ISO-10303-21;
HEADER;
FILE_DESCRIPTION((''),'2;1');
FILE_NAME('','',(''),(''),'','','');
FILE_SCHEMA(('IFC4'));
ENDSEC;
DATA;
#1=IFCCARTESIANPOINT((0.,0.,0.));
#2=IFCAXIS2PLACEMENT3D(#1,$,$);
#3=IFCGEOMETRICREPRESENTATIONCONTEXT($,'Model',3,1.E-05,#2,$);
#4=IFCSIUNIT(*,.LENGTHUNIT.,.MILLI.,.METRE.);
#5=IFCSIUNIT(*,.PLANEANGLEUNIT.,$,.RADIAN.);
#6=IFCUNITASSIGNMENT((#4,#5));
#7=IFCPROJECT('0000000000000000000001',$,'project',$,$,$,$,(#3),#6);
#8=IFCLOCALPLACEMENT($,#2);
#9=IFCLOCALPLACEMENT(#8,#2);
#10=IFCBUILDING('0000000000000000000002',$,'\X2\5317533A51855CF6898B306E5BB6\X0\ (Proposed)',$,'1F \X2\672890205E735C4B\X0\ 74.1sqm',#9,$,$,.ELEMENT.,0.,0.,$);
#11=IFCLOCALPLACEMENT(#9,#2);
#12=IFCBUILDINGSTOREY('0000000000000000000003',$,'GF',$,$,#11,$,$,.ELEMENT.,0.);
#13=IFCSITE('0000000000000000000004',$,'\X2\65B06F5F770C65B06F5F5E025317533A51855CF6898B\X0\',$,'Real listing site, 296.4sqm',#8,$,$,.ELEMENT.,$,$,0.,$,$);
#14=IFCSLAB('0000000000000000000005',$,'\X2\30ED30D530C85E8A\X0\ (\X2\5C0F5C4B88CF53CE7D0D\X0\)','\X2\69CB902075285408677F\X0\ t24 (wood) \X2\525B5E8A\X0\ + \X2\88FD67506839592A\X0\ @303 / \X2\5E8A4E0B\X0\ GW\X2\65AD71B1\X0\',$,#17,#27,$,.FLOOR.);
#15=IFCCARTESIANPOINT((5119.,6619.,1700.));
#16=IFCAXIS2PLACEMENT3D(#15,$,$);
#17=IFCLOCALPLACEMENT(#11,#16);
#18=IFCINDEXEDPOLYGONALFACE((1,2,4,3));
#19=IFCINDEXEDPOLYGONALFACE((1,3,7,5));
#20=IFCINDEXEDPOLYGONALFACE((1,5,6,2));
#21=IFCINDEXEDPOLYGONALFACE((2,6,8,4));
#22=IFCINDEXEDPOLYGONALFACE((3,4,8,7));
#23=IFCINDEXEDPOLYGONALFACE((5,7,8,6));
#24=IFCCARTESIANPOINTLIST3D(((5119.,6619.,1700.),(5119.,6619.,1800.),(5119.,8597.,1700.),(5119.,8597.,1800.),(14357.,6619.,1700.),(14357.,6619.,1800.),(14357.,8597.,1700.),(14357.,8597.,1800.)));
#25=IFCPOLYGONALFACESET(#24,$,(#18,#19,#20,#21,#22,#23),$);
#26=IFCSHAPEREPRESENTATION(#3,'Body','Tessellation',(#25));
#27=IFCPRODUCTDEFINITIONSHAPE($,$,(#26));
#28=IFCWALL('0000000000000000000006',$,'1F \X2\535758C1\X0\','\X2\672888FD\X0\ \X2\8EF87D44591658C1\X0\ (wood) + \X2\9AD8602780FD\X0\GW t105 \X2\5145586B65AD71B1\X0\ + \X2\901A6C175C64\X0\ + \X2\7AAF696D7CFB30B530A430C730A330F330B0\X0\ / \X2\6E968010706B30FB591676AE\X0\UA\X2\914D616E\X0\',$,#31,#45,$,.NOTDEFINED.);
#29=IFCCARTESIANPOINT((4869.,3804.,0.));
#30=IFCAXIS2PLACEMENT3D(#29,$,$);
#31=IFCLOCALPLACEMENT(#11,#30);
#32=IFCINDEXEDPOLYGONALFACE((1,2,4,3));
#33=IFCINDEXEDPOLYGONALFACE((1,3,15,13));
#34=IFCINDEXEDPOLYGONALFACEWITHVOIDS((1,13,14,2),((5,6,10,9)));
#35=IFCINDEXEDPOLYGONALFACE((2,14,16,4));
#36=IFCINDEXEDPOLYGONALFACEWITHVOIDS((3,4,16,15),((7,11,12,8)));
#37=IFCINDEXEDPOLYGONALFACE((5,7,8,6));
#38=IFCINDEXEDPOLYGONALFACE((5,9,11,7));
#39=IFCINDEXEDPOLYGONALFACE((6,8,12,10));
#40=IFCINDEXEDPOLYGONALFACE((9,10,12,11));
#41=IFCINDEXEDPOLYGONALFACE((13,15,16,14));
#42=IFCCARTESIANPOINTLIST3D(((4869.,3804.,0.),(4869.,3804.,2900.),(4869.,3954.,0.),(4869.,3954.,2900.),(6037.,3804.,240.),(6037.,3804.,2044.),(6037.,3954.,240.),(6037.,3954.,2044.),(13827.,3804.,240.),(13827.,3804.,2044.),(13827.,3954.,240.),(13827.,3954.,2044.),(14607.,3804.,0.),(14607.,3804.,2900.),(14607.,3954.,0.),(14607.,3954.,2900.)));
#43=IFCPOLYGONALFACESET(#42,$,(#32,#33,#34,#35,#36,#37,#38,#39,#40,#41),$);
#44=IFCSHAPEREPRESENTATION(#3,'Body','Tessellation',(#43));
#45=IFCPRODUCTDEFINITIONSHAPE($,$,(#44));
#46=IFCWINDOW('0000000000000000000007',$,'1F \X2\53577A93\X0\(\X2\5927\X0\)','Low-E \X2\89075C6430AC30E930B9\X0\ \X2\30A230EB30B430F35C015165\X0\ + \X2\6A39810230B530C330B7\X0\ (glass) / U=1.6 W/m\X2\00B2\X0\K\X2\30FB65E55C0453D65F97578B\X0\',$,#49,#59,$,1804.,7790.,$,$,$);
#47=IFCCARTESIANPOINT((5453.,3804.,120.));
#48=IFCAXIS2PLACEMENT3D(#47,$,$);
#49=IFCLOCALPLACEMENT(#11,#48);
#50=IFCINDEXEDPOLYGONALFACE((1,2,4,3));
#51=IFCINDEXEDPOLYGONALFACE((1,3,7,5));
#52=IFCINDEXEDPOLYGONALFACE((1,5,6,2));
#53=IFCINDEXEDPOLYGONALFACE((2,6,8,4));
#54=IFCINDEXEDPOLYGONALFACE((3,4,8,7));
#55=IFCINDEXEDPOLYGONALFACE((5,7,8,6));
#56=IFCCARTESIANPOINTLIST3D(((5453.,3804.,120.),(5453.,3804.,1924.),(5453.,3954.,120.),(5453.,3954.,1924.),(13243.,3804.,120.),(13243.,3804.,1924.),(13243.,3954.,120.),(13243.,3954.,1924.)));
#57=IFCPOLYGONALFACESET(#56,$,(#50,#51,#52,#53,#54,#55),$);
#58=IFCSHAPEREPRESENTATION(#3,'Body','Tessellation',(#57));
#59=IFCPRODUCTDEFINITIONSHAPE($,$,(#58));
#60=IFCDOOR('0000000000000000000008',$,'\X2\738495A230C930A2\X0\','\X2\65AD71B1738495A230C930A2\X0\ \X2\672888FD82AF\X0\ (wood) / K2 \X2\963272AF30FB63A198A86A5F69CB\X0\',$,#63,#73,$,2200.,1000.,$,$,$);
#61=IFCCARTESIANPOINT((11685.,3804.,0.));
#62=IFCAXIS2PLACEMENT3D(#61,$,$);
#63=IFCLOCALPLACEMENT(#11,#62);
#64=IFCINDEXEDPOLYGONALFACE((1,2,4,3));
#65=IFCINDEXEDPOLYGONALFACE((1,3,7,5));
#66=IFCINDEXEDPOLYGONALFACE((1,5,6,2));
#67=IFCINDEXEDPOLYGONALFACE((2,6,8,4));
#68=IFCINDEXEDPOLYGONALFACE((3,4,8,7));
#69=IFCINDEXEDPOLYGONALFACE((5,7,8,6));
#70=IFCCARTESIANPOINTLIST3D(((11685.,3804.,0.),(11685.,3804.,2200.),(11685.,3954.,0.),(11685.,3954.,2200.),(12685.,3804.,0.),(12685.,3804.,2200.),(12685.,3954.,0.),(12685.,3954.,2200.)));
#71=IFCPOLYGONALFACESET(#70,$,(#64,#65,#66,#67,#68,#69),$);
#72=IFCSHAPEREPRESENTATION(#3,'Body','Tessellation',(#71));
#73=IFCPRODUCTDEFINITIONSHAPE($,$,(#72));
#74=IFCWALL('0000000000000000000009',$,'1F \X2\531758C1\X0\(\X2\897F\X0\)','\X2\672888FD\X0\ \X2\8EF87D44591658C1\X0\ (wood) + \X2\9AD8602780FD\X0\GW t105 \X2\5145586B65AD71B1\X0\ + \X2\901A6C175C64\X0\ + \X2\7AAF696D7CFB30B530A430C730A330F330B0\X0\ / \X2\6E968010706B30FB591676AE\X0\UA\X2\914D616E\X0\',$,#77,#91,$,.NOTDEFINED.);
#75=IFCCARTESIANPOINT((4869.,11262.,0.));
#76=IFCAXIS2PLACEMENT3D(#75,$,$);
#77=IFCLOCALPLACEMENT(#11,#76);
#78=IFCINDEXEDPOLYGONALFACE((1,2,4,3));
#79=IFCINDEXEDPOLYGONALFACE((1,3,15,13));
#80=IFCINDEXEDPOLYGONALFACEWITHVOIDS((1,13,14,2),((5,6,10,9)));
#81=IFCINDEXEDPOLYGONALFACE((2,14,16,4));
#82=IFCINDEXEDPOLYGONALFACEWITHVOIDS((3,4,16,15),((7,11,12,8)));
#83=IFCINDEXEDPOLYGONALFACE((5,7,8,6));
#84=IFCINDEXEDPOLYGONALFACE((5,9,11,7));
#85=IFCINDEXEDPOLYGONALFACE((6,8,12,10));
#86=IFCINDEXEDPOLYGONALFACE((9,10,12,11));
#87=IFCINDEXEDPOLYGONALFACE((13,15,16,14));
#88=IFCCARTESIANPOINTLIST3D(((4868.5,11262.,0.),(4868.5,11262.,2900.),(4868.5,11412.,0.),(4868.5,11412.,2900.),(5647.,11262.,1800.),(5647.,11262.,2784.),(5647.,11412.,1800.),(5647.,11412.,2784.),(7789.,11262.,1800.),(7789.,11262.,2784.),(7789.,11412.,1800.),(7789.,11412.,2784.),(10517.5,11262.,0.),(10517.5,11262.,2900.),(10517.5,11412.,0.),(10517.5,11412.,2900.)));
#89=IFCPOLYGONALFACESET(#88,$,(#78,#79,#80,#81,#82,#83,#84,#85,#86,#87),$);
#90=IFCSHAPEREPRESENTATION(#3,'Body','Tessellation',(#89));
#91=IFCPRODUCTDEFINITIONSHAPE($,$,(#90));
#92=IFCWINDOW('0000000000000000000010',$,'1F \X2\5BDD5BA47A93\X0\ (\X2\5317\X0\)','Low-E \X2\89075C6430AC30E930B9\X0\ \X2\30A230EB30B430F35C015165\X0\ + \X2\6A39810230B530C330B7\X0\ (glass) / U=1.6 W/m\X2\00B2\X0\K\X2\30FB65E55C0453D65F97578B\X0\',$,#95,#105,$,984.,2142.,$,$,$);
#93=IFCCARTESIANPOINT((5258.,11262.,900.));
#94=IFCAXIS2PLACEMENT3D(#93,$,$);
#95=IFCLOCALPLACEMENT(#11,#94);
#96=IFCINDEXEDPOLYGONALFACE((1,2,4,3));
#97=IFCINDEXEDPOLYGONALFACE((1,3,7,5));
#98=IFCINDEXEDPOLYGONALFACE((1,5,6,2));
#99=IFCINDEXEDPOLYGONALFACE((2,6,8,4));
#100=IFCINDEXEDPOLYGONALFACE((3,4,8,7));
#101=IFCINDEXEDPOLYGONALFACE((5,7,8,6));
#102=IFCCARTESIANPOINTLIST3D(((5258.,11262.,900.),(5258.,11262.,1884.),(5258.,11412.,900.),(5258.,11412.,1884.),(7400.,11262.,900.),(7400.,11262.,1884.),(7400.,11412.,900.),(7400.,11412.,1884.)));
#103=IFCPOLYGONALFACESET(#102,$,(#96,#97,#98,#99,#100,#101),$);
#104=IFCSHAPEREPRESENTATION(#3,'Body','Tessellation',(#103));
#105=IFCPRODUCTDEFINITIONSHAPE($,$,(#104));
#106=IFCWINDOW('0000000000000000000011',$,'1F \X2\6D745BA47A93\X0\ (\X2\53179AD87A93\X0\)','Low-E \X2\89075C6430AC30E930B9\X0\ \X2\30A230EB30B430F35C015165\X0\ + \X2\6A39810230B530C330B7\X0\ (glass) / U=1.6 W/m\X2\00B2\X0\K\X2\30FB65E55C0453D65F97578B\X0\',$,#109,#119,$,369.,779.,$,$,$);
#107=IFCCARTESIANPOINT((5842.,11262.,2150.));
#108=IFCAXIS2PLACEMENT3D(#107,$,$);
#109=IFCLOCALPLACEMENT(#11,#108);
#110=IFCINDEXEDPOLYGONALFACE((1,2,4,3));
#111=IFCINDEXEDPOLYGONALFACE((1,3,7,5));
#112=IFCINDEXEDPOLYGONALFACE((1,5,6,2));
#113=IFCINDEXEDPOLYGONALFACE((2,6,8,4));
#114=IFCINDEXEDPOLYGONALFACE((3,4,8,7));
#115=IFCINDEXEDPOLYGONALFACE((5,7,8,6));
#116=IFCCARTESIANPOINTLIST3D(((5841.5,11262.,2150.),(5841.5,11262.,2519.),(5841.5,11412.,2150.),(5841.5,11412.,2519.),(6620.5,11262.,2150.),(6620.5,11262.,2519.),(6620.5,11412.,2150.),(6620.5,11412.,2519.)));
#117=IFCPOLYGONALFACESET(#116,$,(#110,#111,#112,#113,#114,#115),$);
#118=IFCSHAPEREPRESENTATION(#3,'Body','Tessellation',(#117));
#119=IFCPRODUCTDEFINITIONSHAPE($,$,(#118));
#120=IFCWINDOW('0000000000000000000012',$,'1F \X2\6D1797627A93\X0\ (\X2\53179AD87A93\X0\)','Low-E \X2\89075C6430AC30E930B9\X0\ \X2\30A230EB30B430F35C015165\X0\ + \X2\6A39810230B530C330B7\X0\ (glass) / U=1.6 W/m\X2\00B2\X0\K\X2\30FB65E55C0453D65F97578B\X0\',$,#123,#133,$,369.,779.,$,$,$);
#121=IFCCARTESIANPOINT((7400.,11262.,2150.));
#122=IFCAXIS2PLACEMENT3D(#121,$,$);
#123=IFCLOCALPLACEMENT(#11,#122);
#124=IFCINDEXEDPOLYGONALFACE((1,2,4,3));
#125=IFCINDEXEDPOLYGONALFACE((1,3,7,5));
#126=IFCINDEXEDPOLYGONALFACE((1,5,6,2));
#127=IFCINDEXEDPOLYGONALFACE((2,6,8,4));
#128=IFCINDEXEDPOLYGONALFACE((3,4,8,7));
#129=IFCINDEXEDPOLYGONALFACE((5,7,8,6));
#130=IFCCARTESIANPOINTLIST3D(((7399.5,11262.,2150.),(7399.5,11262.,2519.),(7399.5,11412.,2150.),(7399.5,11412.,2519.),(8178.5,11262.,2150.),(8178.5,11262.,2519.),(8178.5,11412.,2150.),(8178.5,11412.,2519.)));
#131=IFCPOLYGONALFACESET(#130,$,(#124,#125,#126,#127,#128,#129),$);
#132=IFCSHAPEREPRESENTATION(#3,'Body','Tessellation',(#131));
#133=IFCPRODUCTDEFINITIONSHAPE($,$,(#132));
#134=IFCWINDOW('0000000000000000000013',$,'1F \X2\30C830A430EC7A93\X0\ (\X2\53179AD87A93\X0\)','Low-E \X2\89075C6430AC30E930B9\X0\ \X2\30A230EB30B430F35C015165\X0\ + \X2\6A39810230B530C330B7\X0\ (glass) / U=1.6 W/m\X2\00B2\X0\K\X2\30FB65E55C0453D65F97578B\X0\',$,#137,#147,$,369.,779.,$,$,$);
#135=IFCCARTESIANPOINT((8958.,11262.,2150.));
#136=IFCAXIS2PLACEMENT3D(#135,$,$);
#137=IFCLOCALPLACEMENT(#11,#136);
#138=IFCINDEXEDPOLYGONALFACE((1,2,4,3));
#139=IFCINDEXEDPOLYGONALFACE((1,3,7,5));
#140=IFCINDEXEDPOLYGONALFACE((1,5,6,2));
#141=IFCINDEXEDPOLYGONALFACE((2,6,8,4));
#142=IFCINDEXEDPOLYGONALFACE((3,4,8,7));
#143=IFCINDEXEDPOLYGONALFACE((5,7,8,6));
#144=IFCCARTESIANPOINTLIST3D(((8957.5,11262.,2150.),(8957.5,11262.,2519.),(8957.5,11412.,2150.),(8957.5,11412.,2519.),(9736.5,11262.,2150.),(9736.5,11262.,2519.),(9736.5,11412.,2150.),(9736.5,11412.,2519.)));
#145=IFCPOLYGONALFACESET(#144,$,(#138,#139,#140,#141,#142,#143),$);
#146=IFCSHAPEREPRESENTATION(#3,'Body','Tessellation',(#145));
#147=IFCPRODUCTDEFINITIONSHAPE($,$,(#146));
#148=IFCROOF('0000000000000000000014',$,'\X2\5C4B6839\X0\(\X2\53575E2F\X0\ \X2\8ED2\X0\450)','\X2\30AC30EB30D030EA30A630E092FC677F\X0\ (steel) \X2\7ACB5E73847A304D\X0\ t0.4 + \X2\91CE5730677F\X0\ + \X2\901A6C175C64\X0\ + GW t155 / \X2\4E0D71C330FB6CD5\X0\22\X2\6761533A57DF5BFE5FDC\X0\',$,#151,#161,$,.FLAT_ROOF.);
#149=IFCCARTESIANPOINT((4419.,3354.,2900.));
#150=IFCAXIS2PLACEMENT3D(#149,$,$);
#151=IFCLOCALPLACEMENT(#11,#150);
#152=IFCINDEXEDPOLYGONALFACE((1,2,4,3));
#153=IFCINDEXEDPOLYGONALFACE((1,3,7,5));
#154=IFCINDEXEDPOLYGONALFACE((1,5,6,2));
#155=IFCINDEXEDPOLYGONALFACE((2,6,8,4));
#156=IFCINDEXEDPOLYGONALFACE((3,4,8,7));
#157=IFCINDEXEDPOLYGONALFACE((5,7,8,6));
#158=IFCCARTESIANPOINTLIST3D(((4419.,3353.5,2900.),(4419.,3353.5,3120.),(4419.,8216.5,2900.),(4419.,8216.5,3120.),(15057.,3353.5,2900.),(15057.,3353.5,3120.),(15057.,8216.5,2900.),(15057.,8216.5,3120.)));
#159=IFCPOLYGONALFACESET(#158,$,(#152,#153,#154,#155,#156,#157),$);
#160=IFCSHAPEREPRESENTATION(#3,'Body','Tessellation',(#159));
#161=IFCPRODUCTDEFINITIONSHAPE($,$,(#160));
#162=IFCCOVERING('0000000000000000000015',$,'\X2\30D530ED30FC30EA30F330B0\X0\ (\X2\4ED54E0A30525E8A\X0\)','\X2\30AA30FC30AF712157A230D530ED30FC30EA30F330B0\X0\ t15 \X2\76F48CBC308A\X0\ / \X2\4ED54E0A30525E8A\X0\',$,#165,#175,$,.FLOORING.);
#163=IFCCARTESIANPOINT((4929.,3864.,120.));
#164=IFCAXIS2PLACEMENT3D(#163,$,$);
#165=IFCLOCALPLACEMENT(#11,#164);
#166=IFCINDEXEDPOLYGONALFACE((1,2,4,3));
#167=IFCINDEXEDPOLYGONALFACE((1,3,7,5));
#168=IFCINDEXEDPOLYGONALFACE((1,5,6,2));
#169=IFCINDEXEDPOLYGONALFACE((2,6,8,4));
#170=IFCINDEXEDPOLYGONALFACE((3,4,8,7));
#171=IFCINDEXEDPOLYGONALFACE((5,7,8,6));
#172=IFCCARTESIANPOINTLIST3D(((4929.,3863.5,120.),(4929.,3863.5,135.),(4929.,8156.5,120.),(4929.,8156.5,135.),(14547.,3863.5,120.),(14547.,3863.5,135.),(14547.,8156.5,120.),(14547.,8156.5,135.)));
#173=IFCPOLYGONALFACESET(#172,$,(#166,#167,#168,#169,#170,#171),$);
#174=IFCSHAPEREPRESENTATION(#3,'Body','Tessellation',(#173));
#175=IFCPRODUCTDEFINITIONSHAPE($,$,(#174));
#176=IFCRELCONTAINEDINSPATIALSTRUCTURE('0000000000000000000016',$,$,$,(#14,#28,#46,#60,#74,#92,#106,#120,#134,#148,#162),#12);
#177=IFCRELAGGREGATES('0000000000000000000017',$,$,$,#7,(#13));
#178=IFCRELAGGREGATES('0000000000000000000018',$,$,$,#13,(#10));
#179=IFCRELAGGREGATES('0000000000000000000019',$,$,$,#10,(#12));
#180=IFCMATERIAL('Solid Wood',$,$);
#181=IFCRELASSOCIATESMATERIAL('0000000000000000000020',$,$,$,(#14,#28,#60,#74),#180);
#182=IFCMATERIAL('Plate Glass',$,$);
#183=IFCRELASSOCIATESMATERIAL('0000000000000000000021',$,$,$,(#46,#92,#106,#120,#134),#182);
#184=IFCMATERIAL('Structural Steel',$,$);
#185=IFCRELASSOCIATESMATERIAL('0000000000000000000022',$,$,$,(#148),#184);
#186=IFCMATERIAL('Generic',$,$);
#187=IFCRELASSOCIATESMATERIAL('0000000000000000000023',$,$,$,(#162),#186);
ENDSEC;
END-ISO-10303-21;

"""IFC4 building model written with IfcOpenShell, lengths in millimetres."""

from ifc_helpers import new_model, si_unit, frame, frame_2d, origin, place, context, project, spatial, rectangle, extrude, material, element, fill, save


model = new_model("IFC4")

# Units and contexts
model_context = context("Model", 3, precision=1e-05, world=origin())
ifc_project = project(units=[si_unit("LENGTHUNIT", "METRE", prefix="MILLI"), si_unit("PLANEANGLEUNIT", "RADIAN")], contexts=[model_context])

# Site, building, storey
site_placement = place(None, origin())
site = spatial("IfcSite", under=ifc_project, at=site_placement, Name="新潟県新潟市北区内島見", ObjectType="Real listing site, 296.4sqm", CompositionType="ELEMENT", RefElevation=0.0)
building_placement = place(site_placement, origin())
building = spatial("IfcBuilding", under=site, at=building_placement, Name="北区内島見の家 (Proposed)", ObjectType="1F 木造平屋 74.1sqm", CompositionType="ELEMENT", ElevationOfRefHeight=0.0, ElevationOfTerrain=0.0)
storey_placement = place(building_placement, origin())
storey = spatial("IfcBuildingStorey", under=building, at=storey_placement, Name="GF", CompositionType="ELEMENT", Elevation=0.0)

# Slab
ifc_material_1 = material(Name="Solid Wood")
slab_1_placement = place(storey_placement, frame((5119.0, 6619.0, 1700.0)))
element("IfcSlab", 1, at=slab_1_placement, inside=storey, material=ifc_material_1, Name="ロフト床 (小屋裏収納)", Description="構造用合板 t24 (wood) 剛床 + 製材根太 @303 / 床下 GW断熱", PredefinedType="FLOOR", context=model_context, shape_type="SweptSolid", body=[
    extrude(rectangle(XDim=9238.0, YDim=1978.0, at=frame_2d((4619.0, 989.0))), frame((5119.0, 6619.0, 1700.0)), (0.0, 0.0, 1.0), 100.0),
])

# Wall, openings, window, door
wall_1_placement = place(storey_placement, frame((4869.0, 3804.0, 0.0)))
wall_1 = element("IfcWall", 2, at=wall_1_placement, inside=storey, material=ifc_material_1, Name="1F 南壁", Description="木製 軸組外壁 (wood) + 高性能GW t105 充填断熱 + 通気層 + 窯業系サイディング / 準耐火・外皮UA配慮", PredefinedType="NOTDEFINED", context=model_context, shape_type="SweptSolid", body=[
    extrude(rectangle(XDim=9738.0, YDim=150.0, at=frame_2d((4869.0, 75.0))), frame((4869.0, 3804.0, 0.0)), (0.0, 0.0, 1.0), 2900.0),
])
opening_1_placement = place(storey_placement, frame((5453.0, 3804.0, 120.0)))
opening_1 = element("IfcOpeningElement", 3, at=opening_1_placement, cuts=wall_1, PredefinedType="NOTDEFINED", context=model_context, shape_type="SweptSolid", body=[
    extrude(rectangle(XDim=7790.0, YDim=150.0, at=frame_2d((3895.0, 75.0))), frame((5453.0, 3804.0, 120.0)), (0.0, 0.0, 1.0), 1804.0),
])
opening_2_placement = place(storey_placement, frame((11685.0, 3804.0, 0.0)))
opening_2 = element("IfcOpeningElement", 4, at=opening_2_placement, cuts=wall_1, PredefinedType="NOTDEFINED", context=model_context, shape_type="SweptSolid", body=[
    extrude(rectangle(XDim=1000.0, YDim=150.0, at=frame_2d((500.0, 75.0))), frame((11685.0, 3804.0, 0.0)), (0.0, 0.0, 1.0), 2200.0),
])
ifc_material_2 = material(Name="Plate Glass")
window_1_placement = place(storey_placement, frame((5453.0, 3804.0, 120.0)))
window_1 = element("IfcWindow", 5, at=window_1_placement, inside=storey, material=ifc_material_2, Name="1F 南窓(大)", Description="Low-E 複層ガラス アルゴン封入 + 樹脂サッシ (glass) / U=1.6 W/m²K・日射取得型", OverallHeight=1804.0, OverallWidth=7790.0, context=model_context, shape_type="SweptSolid", body=[
    extrude(rectangle(XDim=7790.0, YDim=150.0, at=frame_2d((3895.0, 75.0))), frame((5453.0, 3804.0, 120.0)), (0.0, 0.0, 1.0), 1804.0),
])
fill(opening_1, window_1)
door_placement = place(storey_placement, frame((11685.0, 3804.0, 0.0)))
door = element("IfcDoor", 6, at=door_placement, inside=storey, material=ifc_material_1, Name="玄関ドア", Description="断熱玄関ドア 木製芯 (wood) / K2 防犯・採風機構", OverallHeight=2200.0, OverallWidth=1000.0, context=model_context, shape_type="SweptSolid", body=[
    extrude(rectangle(XDim=1000.0, YDim=150.0, at=frame_2d((500.0, 75.0))), frame((11685.0, 3804.0, 0.0)), (0.0, 0.0, 1.0), 2200.0),
])
fill(opening_2, door)

# Wall, openings, windows
wall_2_placement = place(storey_placement, frame((4869.0, 11262.0, 0.0)))
wall_2 = element("IfcWall", 7, at=wall_2_placement, inside=storey, material=ifc_material_1, Name="1F 北壁(西)", Description="木製 軸組外壁 (wood) + 高性能GW t105 充填断熱 + 通気層 + 窯業系サイディング / 準耐火・外皮UA配慮", PredefinedType="NOTDEFINED", context=model_context, shape_type="SweptSolid", body=[
    extrude(rectangle(XDim=5649.0, YDim=150.0, at=frame_2d((2824.0, 75.0))), frame((4869.0, 11262.0, 0.0)), (0.0, 0.0, 1.0), 2900.0),
])
opening_3_placement = place(storey_placement, frame((5258.0, 11262.0, 900.0)))
opening_3 = element("IfcOpeningElement", 8, at=opening_3_placement, cuts=wall_2, PredefinedType="NOTDEFINED", context=model_context, shape_type="SweptSolid", body=[
    extrude(rectangle(XDim=2142.0, YDim=150.0, at=frame_2d((1071.0, 75.0))), frame((5258.0, 11262.0, 900.0)), (0.0, 0.0, 1.0), 984.0),
])
opening_4_placement = place(storey_placement, frame((5842.0, 11262.0, 2150.0)))
opening_4 = element("IfcOpeningElement", 9, at=opening_4_placement, cuts=wall_2, PredefinedType="NOTDEFINED", context=model_context, shape_type="SweptSolid", body=[
    extrude(rectangle(XDim=779.0, YDim=150.0, at=frame_2d((389.0, 75.0))), frame((5842.0, 11262.0, 2150.0)), (0.0, 0.0, 1.0), 369.0),
])
opening_5_placement = place(storey_placement, frame((7400.0, 11262.0, 2150.0)))
opening_5 = element("IfcOpeningElement", 10, at=opening_5_placement, cuts=wall_2, PredefinedType="NOTDEFINED", context=model_context, shape_type="SweptSolid", body=[
    extrude(rectangle(XDim=779.0, YDim=150.0, at=frame_2d((389.0, 75.0))), frame((7400.0, 11262.0, 2150.0)), (0.0, 0.0, 1.0), 369.0),
])
opening_6_placement = place(storey_placement, frame((8958.0, 11262.0, 2150.0)))
opening_6 = element("IfcOpeningElement", 11, at=opening_6_placement, cuts=wall_2, PredefinedType="NOTDEFINED", context=model_context, shape_type="SweptSolid", body=[
    extrude(rectangle(XDim=779.0, YDim=150.0, at=frame_2d((389.0, 75.0))), frame((8958.0, 11262.0, 2150.0)), (0.0, 0.0, 1.0), 369.0),
])
window_2_placement = place(storey_placement, frame((5258.0, 11262.0, 900.0)))
window_2 = element("IfcWindow", 12, at=window_2_placement, inside=storey, material=ifc_material_2, Name="1F 寝室窓 (北)", Description="Low-E 複層ガラス アルゴン封入 + 樹脂サッシ (glass) / U=1.6 W/m²K・日射取得型", OverallHeight=984.0, OverallWidth=2142.0, context=model_context, shape_type="SweptSolid", body=[
    extrude(rectangle(XDim=2142.0, YDim=150.0, at=frame_2d((1071.0, 75.0))), frame((5258.0, 11262.0, 900.0)), (0.0, 0.0, 1.0), 984.0),
])
fill(opening_3, window_2)
window_3_placement = place(storey_placement, frame((5842.0, 11262.0, 2150.0)))
window_3 = element("IfcWindow", 13, at=window_3_placement, inside=storey, material=ifc_material_2, Name="1F 浴室窓 (北高窓)", Description="Low-E 複層ガラス アルゴン封入 + 樹脂サッシ (glass) / U=1.6 W/m²K・日射取得型", OverallHeight=369.0, OverallWidth=779.0, context=model_context, shape_type="SweptSolid", body=[
    extrude(rectangle(XDim=779.0, YDim=150.0, at=frame_2d((389.0, 75.0))), frame((5842.0, 11262.0, 2150.0)), (0.0, 0.0, 1.0), 369.0),
])
fill(opening_4, window_3)
window_4_placement = place(storey_placement, frame((7400.0, 11262.0, 2150.0)))
window_4 = element("IfcWindow", 14, at=window_4_placement, inside=storey, material=ifc_material_2, Name="1F 洗面窓 (北高窓)", Description="Low-E 複層ガラス アルゴン封入 + 樹脂サッシ (glass) / U=1.6 W/m²K・日射取得型", OverallHeight=369.0, OverallWidth=779.0, context=model_context, shape_type="SweptSolid", body=[
    extrude(rectangle(XDim=779.0, YDim=150.0, at=frame_2d((389.0, 75.0))), frame((7400.0, 11262.0, 2150.0)), (0.0, 0.0, 1.0), 369.0),
])
fill(opening_5, window_4)
window_5_placement = place(storey_placement, frame((8958.0, 11262.0, 2150.0)))
window_5 = element("IfcWindow", 15, at=window_5_placement, inside=storey, material=ifc_material_2, Name="1F トイレ窓 (北高窓)", Description="Low-E 複層ガラス アルゴン封入 + 樹脂サッシ (glass) / U=1.6 W/m²K・日射取得型", OverallHeight=369.0, OverallWidth=779.0, context=model_context, shape_type="SweptSolid", body=[
    extrude(rectangle(XDim=779.0, YDim=150.0, at=frame_2d((389.0, 75.0))), frame((8958.0, 11262.0, 2150.0)), (0.0, 0.0, 1.0), 369.0),
])
fill(opening_6, window_5)

# Roof
ifc_material_3 = material(Name="Structural Steel")
roof_1_placement = place(storey_placement, frame((4419.0, 3354.0, 2900.0)))
element("IfcRoof", 16, at=roof_1_placement, inside=storey, material=ifc_material_3, Name="屋根(南帯 軒450)", Description="ガルバリウム鋼板 (steel) 立平葺き t0.4 + 野地板 + 通気層 + GW t155 / 不燃・法22条区域対応", PredefinedType="FLAT_ROOF", context=model_context, shape_type="SweptSolid", body=[
    extrude(rectangle(XDim=10638.0, YDim=4863.0, at=frame_2d((5319.0, 2431.0))), frame((4419.0, 3354.0, 2900.0)), (0.0, 0.0, 1.0), 220.0),
])

# Covering
ifc_material_4 = material(Name="Generic")
covering_1_placement = place(storey_placement, frame((4929.0, 3864.0, 120.0)))
element("IfcCovering", 17, at=covering_1_placement, inside=storey, material=ifc_material_4, Name="フローリング (仕上げ床)", Description="オーク無垢フローリング t15 直貼り / 仕上げ床", PredefinedType="FLOORING", context=model_context, shape_type="SweptSolid", body=[
    extrude(rectangle(XDim=9618.0, YDim=4293.0, at=frame_2d((4809.0, 2146.0))), frame((4929.0, 3864.0, 120.0)), (0.0, 0.0, 1.0), 15.0),
])

save(model, "model.ifc")
